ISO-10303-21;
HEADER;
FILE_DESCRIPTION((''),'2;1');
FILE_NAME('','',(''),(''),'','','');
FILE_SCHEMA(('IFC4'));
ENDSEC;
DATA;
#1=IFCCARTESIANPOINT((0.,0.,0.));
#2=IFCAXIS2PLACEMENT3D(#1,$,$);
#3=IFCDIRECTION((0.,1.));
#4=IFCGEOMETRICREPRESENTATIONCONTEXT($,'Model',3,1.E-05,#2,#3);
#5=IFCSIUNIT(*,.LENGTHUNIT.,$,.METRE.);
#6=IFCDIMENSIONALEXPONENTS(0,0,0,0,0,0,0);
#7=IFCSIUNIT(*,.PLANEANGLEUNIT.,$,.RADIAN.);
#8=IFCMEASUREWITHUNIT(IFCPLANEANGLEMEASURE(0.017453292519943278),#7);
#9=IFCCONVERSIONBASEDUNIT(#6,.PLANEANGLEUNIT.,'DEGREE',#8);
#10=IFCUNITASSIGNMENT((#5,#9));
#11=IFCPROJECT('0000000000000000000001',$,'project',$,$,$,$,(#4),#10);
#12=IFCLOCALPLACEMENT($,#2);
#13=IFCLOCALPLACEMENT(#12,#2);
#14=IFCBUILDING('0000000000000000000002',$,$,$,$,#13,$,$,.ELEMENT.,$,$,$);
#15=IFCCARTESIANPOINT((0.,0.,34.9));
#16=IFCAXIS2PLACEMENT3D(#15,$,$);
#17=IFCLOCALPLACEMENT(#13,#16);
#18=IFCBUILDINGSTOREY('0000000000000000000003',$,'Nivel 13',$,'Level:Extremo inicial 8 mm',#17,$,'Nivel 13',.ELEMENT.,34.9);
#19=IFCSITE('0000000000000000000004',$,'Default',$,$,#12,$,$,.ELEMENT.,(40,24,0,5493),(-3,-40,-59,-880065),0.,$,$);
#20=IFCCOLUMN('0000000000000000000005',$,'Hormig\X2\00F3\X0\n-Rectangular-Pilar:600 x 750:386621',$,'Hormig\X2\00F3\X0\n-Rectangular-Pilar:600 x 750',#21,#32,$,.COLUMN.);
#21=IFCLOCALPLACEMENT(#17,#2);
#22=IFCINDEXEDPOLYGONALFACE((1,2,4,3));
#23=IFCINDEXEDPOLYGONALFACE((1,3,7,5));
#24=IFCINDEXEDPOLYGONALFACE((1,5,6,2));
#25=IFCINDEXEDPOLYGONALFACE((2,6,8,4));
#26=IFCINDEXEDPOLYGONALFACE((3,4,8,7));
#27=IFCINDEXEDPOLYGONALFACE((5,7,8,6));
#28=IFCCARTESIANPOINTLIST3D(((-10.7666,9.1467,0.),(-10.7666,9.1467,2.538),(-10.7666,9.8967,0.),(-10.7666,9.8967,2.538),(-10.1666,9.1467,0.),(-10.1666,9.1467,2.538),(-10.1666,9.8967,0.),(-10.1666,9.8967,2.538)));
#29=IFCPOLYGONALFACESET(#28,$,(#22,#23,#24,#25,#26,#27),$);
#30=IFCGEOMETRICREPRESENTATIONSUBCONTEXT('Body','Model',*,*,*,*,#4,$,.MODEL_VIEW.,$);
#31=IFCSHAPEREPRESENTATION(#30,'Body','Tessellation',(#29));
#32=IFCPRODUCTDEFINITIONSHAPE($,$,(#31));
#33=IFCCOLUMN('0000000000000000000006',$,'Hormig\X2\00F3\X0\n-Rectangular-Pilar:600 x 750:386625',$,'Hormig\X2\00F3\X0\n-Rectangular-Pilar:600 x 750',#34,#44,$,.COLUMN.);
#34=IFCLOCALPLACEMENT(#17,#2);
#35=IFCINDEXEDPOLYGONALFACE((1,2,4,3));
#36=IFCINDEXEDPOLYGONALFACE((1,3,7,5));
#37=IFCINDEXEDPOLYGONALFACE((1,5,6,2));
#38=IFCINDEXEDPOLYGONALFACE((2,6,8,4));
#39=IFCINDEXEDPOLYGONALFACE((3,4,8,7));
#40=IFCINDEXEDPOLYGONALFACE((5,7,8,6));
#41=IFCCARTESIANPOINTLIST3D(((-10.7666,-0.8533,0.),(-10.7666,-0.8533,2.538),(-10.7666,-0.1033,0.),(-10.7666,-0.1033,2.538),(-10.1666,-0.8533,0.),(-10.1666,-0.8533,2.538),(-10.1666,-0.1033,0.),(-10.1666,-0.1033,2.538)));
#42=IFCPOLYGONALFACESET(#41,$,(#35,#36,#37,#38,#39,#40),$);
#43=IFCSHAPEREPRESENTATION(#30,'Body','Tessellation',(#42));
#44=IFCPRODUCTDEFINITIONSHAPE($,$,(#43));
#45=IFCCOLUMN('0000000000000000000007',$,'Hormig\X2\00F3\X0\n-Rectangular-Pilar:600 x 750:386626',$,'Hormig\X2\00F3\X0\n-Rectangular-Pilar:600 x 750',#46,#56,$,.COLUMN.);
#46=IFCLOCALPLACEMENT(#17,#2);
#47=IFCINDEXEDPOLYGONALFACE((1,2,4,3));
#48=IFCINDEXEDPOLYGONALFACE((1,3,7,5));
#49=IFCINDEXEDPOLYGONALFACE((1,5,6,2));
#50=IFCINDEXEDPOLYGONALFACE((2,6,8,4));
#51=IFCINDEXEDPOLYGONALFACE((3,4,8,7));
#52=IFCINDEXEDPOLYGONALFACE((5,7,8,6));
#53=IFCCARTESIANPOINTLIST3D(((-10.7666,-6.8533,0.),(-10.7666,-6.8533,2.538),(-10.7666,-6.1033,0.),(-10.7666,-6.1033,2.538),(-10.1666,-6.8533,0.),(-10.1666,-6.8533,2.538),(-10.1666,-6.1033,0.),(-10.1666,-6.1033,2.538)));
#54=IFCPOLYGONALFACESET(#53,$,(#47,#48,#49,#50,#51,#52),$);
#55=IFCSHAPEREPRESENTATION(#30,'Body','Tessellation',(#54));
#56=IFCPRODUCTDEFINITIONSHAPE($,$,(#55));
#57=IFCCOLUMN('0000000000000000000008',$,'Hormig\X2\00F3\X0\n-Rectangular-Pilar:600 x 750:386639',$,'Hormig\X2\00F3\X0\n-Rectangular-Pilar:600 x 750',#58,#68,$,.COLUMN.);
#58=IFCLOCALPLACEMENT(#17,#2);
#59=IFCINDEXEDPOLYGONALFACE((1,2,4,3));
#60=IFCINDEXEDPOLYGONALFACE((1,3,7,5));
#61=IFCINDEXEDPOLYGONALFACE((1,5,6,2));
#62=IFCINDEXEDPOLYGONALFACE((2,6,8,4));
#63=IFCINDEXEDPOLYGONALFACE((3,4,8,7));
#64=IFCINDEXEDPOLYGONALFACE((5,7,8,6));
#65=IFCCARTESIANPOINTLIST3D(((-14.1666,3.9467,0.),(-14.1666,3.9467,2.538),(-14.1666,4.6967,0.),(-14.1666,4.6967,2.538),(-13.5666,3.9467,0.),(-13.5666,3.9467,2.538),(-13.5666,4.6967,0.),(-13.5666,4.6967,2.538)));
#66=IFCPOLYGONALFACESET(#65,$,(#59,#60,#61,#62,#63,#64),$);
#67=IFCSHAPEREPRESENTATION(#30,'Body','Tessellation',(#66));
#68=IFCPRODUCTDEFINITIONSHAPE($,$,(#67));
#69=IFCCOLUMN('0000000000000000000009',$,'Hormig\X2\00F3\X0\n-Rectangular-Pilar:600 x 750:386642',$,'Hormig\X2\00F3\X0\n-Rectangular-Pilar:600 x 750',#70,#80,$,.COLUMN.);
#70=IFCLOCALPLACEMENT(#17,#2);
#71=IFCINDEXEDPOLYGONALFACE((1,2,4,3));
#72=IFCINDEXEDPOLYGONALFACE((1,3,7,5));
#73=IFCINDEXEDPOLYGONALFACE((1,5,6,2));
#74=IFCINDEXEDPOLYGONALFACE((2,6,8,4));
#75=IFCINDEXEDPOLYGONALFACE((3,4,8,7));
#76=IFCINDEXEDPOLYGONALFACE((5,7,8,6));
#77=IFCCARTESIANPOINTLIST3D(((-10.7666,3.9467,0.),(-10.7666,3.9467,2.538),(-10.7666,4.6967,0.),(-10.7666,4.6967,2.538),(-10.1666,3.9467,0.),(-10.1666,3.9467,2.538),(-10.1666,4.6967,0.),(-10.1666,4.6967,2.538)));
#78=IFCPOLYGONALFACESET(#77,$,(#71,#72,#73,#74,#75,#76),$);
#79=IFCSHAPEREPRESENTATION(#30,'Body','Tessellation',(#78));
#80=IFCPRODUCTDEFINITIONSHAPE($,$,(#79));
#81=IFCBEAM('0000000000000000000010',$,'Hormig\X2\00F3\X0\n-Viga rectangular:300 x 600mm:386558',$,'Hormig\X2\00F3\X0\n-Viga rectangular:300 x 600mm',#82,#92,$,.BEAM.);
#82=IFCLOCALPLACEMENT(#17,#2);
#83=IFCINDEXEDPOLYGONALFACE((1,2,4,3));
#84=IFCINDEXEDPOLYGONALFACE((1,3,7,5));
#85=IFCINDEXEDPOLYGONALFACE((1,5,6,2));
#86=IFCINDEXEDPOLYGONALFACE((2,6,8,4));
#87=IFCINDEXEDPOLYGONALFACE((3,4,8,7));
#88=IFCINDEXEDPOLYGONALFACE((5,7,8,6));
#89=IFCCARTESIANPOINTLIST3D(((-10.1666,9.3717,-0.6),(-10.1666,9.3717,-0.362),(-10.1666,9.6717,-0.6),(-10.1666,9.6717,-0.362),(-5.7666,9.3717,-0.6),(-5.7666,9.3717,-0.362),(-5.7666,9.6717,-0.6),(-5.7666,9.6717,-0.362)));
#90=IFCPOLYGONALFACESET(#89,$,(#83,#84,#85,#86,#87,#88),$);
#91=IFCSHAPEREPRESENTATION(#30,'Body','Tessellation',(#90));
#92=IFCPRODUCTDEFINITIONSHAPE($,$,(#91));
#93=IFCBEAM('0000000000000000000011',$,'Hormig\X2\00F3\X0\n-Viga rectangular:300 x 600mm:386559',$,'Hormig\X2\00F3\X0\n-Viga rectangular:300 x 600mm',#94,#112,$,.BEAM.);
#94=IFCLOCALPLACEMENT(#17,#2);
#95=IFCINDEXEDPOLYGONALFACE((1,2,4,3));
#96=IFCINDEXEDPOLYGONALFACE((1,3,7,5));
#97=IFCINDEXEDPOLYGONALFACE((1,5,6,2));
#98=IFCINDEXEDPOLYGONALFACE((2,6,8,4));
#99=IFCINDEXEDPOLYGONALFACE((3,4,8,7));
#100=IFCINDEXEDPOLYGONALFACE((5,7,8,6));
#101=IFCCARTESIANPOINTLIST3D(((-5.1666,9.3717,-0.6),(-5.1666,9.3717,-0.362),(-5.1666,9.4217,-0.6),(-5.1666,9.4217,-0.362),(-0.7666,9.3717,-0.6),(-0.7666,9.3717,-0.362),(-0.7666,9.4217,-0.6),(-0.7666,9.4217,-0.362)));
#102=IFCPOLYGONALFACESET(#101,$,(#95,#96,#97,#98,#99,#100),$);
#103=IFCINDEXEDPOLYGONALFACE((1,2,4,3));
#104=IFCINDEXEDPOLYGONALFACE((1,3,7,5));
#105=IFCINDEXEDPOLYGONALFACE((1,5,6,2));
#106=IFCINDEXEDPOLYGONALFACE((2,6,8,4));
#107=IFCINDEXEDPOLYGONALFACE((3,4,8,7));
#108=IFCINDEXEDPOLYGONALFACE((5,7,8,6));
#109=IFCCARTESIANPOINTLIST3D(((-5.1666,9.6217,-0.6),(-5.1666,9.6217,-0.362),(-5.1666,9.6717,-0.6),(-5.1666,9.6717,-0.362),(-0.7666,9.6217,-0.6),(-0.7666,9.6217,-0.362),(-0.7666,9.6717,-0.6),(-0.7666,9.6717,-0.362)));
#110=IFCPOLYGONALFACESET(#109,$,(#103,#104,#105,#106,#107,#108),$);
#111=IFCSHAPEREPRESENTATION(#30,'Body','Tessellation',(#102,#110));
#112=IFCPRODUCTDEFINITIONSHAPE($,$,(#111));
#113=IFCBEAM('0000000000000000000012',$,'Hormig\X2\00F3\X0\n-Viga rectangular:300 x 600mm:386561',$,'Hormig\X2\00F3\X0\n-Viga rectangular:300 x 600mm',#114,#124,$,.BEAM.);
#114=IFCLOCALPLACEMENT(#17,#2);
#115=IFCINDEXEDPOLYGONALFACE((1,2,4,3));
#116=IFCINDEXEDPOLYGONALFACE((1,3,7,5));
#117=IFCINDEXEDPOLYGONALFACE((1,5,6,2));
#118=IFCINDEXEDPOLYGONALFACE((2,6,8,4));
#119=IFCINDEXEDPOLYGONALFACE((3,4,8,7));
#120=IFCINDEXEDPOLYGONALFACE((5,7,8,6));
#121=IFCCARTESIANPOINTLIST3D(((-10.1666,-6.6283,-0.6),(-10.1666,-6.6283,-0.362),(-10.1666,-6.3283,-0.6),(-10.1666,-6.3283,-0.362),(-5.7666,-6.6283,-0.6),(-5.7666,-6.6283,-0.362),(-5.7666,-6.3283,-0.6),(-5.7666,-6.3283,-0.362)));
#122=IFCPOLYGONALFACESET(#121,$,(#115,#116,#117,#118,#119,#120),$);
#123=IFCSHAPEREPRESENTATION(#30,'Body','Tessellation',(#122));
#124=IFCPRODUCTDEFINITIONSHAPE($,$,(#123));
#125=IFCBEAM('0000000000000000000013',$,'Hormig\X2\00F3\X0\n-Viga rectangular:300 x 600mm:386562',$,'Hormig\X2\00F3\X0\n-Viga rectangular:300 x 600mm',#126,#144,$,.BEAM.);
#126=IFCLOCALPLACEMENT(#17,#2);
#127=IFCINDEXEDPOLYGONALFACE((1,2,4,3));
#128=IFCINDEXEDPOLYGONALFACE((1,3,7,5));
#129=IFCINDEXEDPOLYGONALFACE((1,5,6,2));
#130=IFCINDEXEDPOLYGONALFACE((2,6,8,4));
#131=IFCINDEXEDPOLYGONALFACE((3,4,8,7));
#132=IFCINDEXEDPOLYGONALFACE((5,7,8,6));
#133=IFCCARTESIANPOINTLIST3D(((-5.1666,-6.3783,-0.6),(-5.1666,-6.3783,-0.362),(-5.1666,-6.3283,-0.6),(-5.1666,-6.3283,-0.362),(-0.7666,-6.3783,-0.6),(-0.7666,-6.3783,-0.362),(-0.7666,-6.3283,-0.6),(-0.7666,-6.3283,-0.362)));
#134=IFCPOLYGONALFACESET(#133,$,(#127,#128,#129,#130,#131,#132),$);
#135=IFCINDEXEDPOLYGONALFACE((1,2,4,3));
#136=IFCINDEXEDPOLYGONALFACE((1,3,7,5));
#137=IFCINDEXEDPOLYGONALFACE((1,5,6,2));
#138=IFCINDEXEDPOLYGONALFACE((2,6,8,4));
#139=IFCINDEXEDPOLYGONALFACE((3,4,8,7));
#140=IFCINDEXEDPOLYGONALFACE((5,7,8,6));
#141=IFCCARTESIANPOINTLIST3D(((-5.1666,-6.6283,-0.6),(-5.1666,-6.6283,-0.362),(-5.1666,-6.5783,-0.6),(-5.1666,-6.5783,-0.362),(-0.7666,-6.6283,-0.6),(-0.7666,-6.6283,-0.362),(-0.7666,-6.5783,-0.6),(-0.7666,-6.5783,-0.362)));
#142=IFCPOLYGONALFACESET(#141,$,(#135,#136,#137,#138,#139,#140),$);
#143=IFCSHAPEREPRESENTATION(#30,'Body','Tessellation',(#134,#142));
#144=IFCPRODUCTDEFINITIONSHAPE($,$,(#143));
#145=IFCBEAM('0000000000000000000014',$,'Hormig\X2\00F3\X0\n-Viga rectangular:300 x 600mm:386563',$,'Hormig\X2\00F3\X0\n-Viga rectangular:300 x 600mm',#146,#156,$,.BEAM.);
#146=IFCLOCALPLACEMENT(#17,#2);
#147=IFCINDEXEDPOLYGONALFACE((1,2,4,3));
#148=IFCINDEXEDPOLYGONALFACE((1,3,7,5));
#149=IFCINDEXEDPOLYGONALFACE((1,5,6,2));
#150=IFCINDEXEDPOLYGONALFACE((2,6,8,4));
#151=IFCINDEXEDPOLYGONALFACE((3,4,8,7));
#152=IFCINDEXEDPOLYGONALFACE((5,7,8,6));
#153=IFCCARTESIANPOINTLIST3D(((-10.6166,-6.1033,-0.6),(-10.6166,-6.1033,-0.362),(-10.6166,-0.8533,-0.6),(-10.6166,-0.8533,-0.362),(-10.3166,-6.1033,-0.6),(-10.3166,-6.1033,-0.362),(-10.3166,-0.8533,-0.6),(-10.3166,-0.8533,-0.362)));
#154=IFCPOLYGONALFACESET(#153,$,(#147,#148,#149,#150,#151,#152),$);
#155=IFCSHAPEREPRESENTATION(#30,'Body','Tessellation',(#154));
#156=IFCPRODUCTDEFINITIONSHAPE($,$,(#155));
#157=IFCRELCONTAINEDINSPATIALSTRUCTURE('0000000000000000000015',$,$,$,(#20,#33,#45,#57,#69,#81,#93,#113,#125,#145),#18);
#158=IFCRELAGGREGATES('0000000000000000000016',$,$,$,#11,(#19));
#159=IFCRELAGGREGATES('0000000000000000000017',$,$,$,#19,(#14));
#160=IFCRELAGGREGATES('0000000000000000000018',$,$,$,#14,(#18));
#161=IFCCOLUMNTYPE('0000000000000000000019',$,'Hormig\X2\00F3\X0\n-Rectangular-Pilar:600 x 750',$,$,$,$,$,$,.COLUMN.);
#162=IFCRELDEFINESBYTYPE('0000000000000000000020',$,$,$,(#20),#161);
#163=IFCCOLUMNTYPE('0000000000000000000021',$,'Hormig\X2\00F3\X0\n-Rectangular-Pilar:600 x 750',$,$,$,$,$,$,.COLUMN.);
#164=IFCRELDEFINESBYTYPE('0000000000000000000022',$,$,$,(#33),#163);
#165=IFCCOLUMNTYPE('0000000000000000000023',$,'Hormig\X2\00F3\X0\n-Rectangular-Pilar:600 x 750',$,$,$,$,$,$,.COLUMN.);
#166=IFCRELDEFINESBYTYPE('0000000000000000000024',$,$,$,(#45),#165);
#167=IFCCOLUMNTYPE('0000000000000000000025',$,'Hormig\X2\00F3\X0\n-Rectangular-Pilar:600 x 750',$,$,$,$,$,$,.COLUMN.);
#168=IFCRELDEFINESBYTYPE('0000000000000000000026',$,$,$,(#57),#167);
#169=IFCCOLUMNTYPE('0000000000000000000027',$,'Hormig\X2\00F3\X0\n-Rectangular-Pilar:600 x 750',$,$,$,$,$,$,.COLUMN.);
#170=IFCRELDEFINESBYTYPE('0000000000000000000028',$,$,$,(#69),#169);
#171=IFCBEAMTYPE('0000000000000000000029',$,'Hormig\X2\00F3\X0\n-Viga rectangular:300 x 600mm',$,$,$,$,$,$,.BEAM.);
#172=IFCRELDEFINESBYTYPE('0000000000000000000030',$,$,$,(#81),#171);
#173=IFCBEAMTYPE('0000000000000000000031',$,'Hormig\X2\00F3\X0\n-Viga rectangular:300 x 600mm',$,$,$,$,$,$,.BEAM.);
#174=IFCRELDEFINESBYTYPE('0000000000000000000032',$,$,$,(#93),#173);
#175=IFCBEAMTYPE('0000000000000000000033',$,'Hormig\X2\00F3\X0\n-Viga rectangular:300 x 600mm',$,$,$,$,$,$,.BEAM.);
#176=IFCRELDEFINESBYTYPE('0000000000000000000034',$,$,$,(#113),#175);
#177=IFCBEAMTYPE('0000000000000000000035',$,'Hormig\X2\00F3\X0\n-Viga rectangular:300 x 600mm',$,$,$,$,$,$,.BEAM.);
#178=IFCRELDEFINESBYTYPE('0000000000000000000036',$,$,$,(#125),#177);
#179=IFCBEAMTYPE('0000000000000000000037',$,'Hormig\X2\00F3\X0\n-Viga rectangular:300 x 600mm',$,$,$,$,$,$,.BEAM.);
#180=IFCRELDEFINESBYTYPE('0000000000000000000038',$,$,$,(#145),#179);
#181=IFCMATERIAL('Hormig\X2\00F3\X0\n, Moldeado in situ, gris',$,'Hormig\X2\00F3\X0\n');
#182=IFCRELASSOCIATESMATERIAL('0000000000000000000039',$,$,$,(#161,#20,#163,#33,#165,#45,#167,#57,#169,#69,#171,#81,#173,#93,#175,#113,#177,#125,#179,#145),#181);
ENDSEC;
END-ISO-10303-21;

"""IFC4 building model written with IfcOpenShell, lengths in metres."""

from ifc_helpers import new_model, entity, si_unit, converted_unit, direction, frame, origin, place, context, subcontext, project, spatial, indexed_curve, outline, extrude, source, transform, mapped, material, type_object, type_shapes, element, save


model = new_model("IFC4")

# Units and contexts
model_context = context("Model", 3, precision=1e-05, world=origin(), true_north=direction((0.0, 1.0)))
body_context = subcontext(model_context, "Body", "Model", "MODEL_VIEW")
ifc_project = project(units=[si_unit("LENGTHUNIT", "METRE"), converted_unit("PLANEANGLEUNIT", "DEGREE", entity("IfcPlaneAngleMeasure", 0.017453292519943278), si_unit("PLANEANGLEUNIT", "RADIAN"), dimensions=[0, 0, 0, 0, 0, 0, 0])], contexts=[model_context])

# Site, building, storey
site_placement = place(None, origin())
site = spatial("IfcSite", under=ifc_project, at=site_placement, Name="Default", CompositionType="ELEMENT", RefLatitude=(40, 24, 0, 5493), RefLongitude=(-3, -40, -59, -880065), RefElevation=0.0)
building_placement = place(site_placement, origin())
building = spatial("IfcBuilding", under=site, at=building_placement, CompositionType="ELEMENT")
storey_placement = place(building_placement, frame((0.0, 0.0, 34.9)))
storey = spatial("IfcBuildingStorey", under=building, at=storey_placement, Name="Nivel 13", ObjectType="Level:Extremo inicial 8 mm", LongName="Nivel 13", CompositionType="ELEMENT", Elevation=34.9)

# Columns
ifc_material_1 = material(Name="Hormigón, Moldeado in situ, gris", Category="Hormigón")
column_type_1 = type_object("IfcColumnType", Name="Hormigón-Rectangular-Pilar:600 x 750", PredefinedType="COLUMN", material=ifc_material_1)
shared_shape_1 = source(origin(), body_context, "Body", "SweptSolid", [
    extrude(outline(indexed_curve([(-0.3, -0.375), (0.3, -0.375), (0.3, 0.375), (-0.3, 0.375), (-0.3, -0.375)], self_intersect=False)), frame((-10.4666, 9.5217, 34.9), z_axis=(0.0, 0.0, 1.0), x_axis=(-1.0, 0.0, 0.0)), (0.0, 0.0, 1.0), 2.538),
])
type_shapes(column_type_1, [shared_shape_1])
column_1_placement = place(storey_placement, frame((0.0, 0.0, -34.9)))
element("IfcColumn", 1, at=column_1_placement, inside=storey, type_object=column_type_1, material=ifc_material_1, Name="Hormigón-Rectangular-Pilar:600 x 750:386621", ObjectType="Hormigón-Rectangular-Pilar:600 x 750", PredefinedType="COLUMN", context=body_context, shape_type="MappedRepresentation", body=[
    mapped(shared_shape_1, transform((0.0, 0.0, 0.0), scale=1.0)),
])
column_type_2 = type_object("IfcColumnType", Name="Hormigón-Rectangular-Pilar:600 x 750", PredefinedType="COLUMN", material=ifc_material_1)
shared_shape_2 = source(origin(), body_context, "Body", "SweptSolid", [
    extrude(outline(indexed_curve([(-0.3, -0.375), (0.3, -0.375), (0.3, 0.375), (-0.3, 0.375), (-0.3, -0.375)], self_intersect=False)), frame((-10.4666, -0.4783, 34.9), z_axis=(0.0, 0.0, 1.0), x_axis=(-1.0, 0.0, 0.0)), (0.0, 0.0, 1.0), 2.538),
])
type_shapes(column_type_2, [shared_shape_2])
column_2_placement = place(storey_placement, frame((0.0, 0.0, -34.9)))
element("IfcColumn", 2, at=column_2_placement, inside=storey, type_object=column_type_2, material=ifc_material_1, Name="Hormigón-Rectangular-Pilar:600 x 750:386625", ObjectType="Hormigón-Rectangular-Pilar:600 x 750", PredefinedType="COLUMN", context=body_context, shape_type="MappedRepresentation", body=[
    mapped(shared_shape_2, transform((0.0, 0.0, 0.0), scale=1.0)),
])
column_type_3 = type_object("IfcColumnType", Name="Hormigón-Rectangular-Pilar:600 x 750", PredefinedType="COLUMN", material=ifc_material_1)
shared_shape_3 = source(origin(), body_context, "Body", "SweptSolid", [
    extrude(outline(indexed_curve([(-0.3, -0.375), (0.3, -0.375), (0.3, 0.375), (-0.3, 0.375), (-0.3, -0.375)], self_intersect=False)), frame((-10.4666, -6.4783, 34.9), z_axis=(0.0, 0.0, 1.0), x_axis=(-1.0, 0.0, 0.0)), (0.0, 0.0, 1.0), 2.538),
])
type_shapes(column_type_3, [shared_shape_3])
column_3_placement = place(storey_placement, frame((0.0, 0.0, -34.9)))
element("IfcColumn", 3, at=column_3_placement, inside=storey, type_object=column_type_3, material=ifc_material_1, Name="Hormigón-Rectangular-Pilar:600 x 750:386626", ObjectType="Hormigón-Rectangular-Pilar:600 x 750", PredefinedType="COLUMN", context=body_context, shape_type="MappedRepresentation", body=[
    mapped(shared_shape_3, transform((0.0, 0.0, 0.0), scale=1.0)),
])
column_type_4 = type_object("IfcColumnType", Name="Hormigón-Rectangular-Pilar:600 x 750", PredefinedType="COLUMN", material=ifc_material_1)
shared_shape_4 = source(origin(), body_context, "Body", "SweptSolid", [
    extrude(outline(indexed_curve([(-0.3, -0.375), (0.3, -0.375), (0.3, 0.375), (-0.3, 0.375), (-0.3, -0.375)], self_intersect=False)), frame((-13.8666, 4.3217, 34.9), z_axis=(0.0, 0.0, 1.0), x_axis=(-1.0, 0.0, 0.0)), (0.0, 0.0, 1.0), 2.538),
])
type_shapes(column_type_4, [shared_shape_4])
column_4_placement = place(storey_placement, frame((0.0, 0.0, -34.9)))
element("IfcColumn", 4, at=column_4_placement, inside=storey, type_object=column_type_4, material=ifc_material_1, Name="Hormigón-Rectangular-Pilar:600 x 750:386639", ObjectType="Hormigón-Rectangular-Pilar:600 x 750", PredefinedType="COLUMN", context=body_context, shape_type="MappedRepresentation", body=[
    mapped(shared_shape_4, transform((0.0, 0.0, 0.0), scale=1.0)),
])
column_type_5 = type_object("IfcColumnType", Name="Hormigón-Rectangular-Pilar:600 x 750", PredefinedType="COLUMN", material=ifc_material_1)
shared_shape_5 = source(origin(), body_context, "Body", "SweptSolid", [
    extrude(outline(indexed_curve([(-0.3, -0.375), (0.3, -0.375), (0.3, 0.375), (-0.3, 0.375), (-0.3, -0.375)], self_intersect=False)), frame((-10.4666, 4.3217, 34.9), z_axis=(0.0, 0.0, 1.0), x_axis=(-1.0, 0.0, 0.0)), (0.0, 0.0, 1.0), 2.538),
])
type_shapes(column_type_5, [shared_shape_5])
column_5_placement = place(storey_placement, frame((0.0, 0.0, -34.9)))
element("IfcColumn", 5, at=column_5_placement, inside=storey, type_object=column_type_5, material=ifc_material_1, Name="Hormigón-Rectangular-Pilar:600 x 750:386642", ObjectType="Hormigón-Rectangular-Pilar:600 x 750", PredefinedType="COLUMN", context=body_context, shape_type="MappedRepresentation", body=[
    mapped(shared_shape_5, transform((0.0, 0.0, 0.0), scale=1.0)),
])

# Beams
beam_type_1 = type_object("IfcBeamType", Name="Hormigón-Viga rectangular:300 x 600mm", PredefinedType="BEAM", material=ifc_material_1)
shared_shape_6 = source(origin(), body_context, "Body", "SweptSolid", [
    extrude(outline(indexed_curve([(-0.119, -0.15), (0.119, -0.15), (0.119, 0.15), (-0.119, 0.15), (-0.119, -0.15)], self_intersect=False)), frame((-5.7666, 9.5217, 34.419), z_axis=(-1.0, 0.0, 0.0), x_axis=(0.0, 0.0, -1.0)), (0.0, 0.0, 1.0), 4.4),
])
type_shapes(beam_type_1, [shared_shape_6])
beam_1_placement = place(storey_placement, frame((0.0, 0.0, -34.9)))
element("IfcBeam", 6, at=beam_1_placement, inside=storey, type_object=beam_type_1, material=ifc_material_1, Name="Hormigón-Viga rectangular:300 x 600mm:386558", ObjectType="Hormigón-Viga rectangular:300 x 600mm", PredefinedType="BEAM", context=body_context, shape_type="MappedRepresentation", body=[
    mapped(shared_shape_6, transform((0.0, 0.0, 0.0), scale=1.0)),
])
beam_type_2 = type_object("IfcBeamType", Name="Hormigón-Viga rectangular:300 x 600mm", PredefinedType="BEAM", material=ifc_material_1)
shared_shape_7 = source(origin(), body_context, "Body", "SweptSolid", [
    extrude(outline(indexed_curve([(-0.119, -0.025), (0.119, -0.025), (0.119, 0.025), (-0.119, 0.025), (-0.119, -0.025)], self_intersect=False)), frame((-5.1666, 9.3967, 34.419), z_axis=(1.0, 0.0, 0.0), x_axis=(0.0, 0.0, -1.0)), (0.0, 0.0, 1.0), 4.4),
    extrude(outline(indexed_curve([(-0.119, -0.025), (0.119, -0.025), (0.119, 0.025), (-0.119, 0.025), (-0.119, -0.025)], self_intersect=False)), frame((-5.1666, 9.6467, 34.419), z_axis=(1.0, 0.0, 0.0), x_axis=(0.0, 0.0, -1.0)), (0.0, 0.0, 1.0), 4.4),
])
type_shapes(beam_type_2, [shared_shape_7])
beam_2_placement = place(storey_placement, frame((0.0, 0.0, -34.9)))
element("IfcBeam", 7, at=beam_2_placement, inside=storey, type_object=beam_type_2, material=ifc_material_1, Name="Hormigón-Viga rectangular:300 x 600mm:386559", ObjectType="Hormigón-Viga rectangular:300 x 600mm", PredefinedType="BEAM", context=body_context, shape_type="MappedRepresentation", body=[
    mapped(shared_shape_7, transform((0.0, 0.0, 0.0), scale=1.0)),
])
beam_type_3 = type_object("IfcBeamType", Name="Hormigón-Viga rectangular:300 x 600mm", PredefinedType="BEAM", material=ifc_material_1)
shared_shape_8 = source(origin(), body_context, "Body", "SweptSolid", [
    extrude(outline(indexed_curve([(-0.119, -0.15), (0.119, -0.15), (0.119, 0.15), (-0.119, 0.15), (-0.119, -0.15)], self_intersect=False)), frame((-10.1666, -6.4783, 34.419), z_axis=(1.0, 0.0, 0.0), x_axis=(0.0, 0.0, -1.0)), (0.0, 0.0, 1.0), 4.4),
])
type_shapes(beam_type_3, [shared_shape_8])
beam_3_placement = place(storey_placement, frame((0.0, 0.0, -34.9)))
element("IfcBeam", 8, at=beam_3_placement, inside=storey, type_object=beam_type_3, material=ifc_material_1, Name="Hormigón-Viga rectangular:300 x 600mm:386561", ObjectType="Hormigón-Viga rectangular:300 x 600mm", PredefinedType="BEAM", context=body_context, shape_type="MappedRepresentation", body=[
    mapped(shared_shape_8, transform((0.0, 0.0, 0.0), scale=1.0)),
])
beam_type_4 = type_object("IfcBeamType", Name="Hormigón-Viga rectangular:300 x 600mm", PredefinedType="BEAM", material=ifc_material_1)
shared_shape_9 = source(origin(), body_context, "Body", "SweptSolid", [
    extrude(outline(indexed_curve([(-0.119, -0.025), (0.119, -0.025), (0.119, 0.025), (-0.119, 0.025), (-0.119, -0.025)], self_intersect=False)), frame((-0.7666, -6.3533, 34.419), z_axis=(-1.0, 0.0, 0.0), x_axis=(0.0, 0.0, -1.0)), (0.0, 0.0, 1.0), 4.4),
    extrude(outline(indexed_curve([(-0.119, -0.025), (0.119, -0.025), (0.119, 0.025), (-0.119, 0.025), (-0.119, -0.025)], self_intersect=False)), frame((-0.7666, -6.6033, 34.419), z_axis=(-1.0, 0.0, 0.0), x_axis=(0.0, 0.0, -1.0)), (0.0, 0.0, 1.0), 4.4),
])
type_shapes(beam_type_4, [shared_shape_9])
beam_4_placement = place(storey_placement, frame((0.0, 0.0, -34.9)))
element("IfcBeam", 9, at=beam_4_placement, inside=storey, type_object=beam_type_4, material=ifc_material_1, Name="Hormigón-Viga rectangular:300 x 600mm:386562", ObjectType="Hormigón-Viga rectangular:300 x 600mm", PredefinedType="BEAM", context=body_context, shape_type="MappedRepresentation", body=[
    mapped(shared_shape_9, transform((0.0, 0.0, 0.0), scale=1.0)),
])
beam_type_5 = type_object("IfcBeamType", Name="Hormigón-Viga rectangular:300 x 600mm", PredefinedType="BEAM", material=ifc_material_1)
shared_shape_10 = source(origin(), body_context, "Body", "SweptSolid", [
    extrude(outline(indexed_curve([(-0.15, -0.119), (0.15, -0.119), (0.15, 0.119), (-0.15, 0.119), (-0.15, -0.119)], self_intersect=False)), frame((-10.4666, -6.1033, 34.419), z_axis=(0.0, 1.0, 0.0), x_axis=(-1.0, 0.0, 0.0)), (0.0, 0.0, 1.0), 5.25),
])
type_shapes(beam_type_5, [shared_shape_10])
beam_5_placement = place(storey_placement, frame((0.0, 0.0, -34.9)))
element("IfcBeam", 10, at=beam_5_placement, inside=storey, type_object=beam_type_5, material=ifc_material_1, Name="Hormigón-Viga rectangular:300 x 600mm:386563", ObjectType="Hormigón-Viga rectangular:300 x 600mm", PredefinedType="BEAM", context=body_context, shape_type="MappedRepresentation", body=[
    mapped(shared_shape_10, transform((0.0, 0.0, 0.0), scale=1.0)),
])

save(model, "model.ifc")
